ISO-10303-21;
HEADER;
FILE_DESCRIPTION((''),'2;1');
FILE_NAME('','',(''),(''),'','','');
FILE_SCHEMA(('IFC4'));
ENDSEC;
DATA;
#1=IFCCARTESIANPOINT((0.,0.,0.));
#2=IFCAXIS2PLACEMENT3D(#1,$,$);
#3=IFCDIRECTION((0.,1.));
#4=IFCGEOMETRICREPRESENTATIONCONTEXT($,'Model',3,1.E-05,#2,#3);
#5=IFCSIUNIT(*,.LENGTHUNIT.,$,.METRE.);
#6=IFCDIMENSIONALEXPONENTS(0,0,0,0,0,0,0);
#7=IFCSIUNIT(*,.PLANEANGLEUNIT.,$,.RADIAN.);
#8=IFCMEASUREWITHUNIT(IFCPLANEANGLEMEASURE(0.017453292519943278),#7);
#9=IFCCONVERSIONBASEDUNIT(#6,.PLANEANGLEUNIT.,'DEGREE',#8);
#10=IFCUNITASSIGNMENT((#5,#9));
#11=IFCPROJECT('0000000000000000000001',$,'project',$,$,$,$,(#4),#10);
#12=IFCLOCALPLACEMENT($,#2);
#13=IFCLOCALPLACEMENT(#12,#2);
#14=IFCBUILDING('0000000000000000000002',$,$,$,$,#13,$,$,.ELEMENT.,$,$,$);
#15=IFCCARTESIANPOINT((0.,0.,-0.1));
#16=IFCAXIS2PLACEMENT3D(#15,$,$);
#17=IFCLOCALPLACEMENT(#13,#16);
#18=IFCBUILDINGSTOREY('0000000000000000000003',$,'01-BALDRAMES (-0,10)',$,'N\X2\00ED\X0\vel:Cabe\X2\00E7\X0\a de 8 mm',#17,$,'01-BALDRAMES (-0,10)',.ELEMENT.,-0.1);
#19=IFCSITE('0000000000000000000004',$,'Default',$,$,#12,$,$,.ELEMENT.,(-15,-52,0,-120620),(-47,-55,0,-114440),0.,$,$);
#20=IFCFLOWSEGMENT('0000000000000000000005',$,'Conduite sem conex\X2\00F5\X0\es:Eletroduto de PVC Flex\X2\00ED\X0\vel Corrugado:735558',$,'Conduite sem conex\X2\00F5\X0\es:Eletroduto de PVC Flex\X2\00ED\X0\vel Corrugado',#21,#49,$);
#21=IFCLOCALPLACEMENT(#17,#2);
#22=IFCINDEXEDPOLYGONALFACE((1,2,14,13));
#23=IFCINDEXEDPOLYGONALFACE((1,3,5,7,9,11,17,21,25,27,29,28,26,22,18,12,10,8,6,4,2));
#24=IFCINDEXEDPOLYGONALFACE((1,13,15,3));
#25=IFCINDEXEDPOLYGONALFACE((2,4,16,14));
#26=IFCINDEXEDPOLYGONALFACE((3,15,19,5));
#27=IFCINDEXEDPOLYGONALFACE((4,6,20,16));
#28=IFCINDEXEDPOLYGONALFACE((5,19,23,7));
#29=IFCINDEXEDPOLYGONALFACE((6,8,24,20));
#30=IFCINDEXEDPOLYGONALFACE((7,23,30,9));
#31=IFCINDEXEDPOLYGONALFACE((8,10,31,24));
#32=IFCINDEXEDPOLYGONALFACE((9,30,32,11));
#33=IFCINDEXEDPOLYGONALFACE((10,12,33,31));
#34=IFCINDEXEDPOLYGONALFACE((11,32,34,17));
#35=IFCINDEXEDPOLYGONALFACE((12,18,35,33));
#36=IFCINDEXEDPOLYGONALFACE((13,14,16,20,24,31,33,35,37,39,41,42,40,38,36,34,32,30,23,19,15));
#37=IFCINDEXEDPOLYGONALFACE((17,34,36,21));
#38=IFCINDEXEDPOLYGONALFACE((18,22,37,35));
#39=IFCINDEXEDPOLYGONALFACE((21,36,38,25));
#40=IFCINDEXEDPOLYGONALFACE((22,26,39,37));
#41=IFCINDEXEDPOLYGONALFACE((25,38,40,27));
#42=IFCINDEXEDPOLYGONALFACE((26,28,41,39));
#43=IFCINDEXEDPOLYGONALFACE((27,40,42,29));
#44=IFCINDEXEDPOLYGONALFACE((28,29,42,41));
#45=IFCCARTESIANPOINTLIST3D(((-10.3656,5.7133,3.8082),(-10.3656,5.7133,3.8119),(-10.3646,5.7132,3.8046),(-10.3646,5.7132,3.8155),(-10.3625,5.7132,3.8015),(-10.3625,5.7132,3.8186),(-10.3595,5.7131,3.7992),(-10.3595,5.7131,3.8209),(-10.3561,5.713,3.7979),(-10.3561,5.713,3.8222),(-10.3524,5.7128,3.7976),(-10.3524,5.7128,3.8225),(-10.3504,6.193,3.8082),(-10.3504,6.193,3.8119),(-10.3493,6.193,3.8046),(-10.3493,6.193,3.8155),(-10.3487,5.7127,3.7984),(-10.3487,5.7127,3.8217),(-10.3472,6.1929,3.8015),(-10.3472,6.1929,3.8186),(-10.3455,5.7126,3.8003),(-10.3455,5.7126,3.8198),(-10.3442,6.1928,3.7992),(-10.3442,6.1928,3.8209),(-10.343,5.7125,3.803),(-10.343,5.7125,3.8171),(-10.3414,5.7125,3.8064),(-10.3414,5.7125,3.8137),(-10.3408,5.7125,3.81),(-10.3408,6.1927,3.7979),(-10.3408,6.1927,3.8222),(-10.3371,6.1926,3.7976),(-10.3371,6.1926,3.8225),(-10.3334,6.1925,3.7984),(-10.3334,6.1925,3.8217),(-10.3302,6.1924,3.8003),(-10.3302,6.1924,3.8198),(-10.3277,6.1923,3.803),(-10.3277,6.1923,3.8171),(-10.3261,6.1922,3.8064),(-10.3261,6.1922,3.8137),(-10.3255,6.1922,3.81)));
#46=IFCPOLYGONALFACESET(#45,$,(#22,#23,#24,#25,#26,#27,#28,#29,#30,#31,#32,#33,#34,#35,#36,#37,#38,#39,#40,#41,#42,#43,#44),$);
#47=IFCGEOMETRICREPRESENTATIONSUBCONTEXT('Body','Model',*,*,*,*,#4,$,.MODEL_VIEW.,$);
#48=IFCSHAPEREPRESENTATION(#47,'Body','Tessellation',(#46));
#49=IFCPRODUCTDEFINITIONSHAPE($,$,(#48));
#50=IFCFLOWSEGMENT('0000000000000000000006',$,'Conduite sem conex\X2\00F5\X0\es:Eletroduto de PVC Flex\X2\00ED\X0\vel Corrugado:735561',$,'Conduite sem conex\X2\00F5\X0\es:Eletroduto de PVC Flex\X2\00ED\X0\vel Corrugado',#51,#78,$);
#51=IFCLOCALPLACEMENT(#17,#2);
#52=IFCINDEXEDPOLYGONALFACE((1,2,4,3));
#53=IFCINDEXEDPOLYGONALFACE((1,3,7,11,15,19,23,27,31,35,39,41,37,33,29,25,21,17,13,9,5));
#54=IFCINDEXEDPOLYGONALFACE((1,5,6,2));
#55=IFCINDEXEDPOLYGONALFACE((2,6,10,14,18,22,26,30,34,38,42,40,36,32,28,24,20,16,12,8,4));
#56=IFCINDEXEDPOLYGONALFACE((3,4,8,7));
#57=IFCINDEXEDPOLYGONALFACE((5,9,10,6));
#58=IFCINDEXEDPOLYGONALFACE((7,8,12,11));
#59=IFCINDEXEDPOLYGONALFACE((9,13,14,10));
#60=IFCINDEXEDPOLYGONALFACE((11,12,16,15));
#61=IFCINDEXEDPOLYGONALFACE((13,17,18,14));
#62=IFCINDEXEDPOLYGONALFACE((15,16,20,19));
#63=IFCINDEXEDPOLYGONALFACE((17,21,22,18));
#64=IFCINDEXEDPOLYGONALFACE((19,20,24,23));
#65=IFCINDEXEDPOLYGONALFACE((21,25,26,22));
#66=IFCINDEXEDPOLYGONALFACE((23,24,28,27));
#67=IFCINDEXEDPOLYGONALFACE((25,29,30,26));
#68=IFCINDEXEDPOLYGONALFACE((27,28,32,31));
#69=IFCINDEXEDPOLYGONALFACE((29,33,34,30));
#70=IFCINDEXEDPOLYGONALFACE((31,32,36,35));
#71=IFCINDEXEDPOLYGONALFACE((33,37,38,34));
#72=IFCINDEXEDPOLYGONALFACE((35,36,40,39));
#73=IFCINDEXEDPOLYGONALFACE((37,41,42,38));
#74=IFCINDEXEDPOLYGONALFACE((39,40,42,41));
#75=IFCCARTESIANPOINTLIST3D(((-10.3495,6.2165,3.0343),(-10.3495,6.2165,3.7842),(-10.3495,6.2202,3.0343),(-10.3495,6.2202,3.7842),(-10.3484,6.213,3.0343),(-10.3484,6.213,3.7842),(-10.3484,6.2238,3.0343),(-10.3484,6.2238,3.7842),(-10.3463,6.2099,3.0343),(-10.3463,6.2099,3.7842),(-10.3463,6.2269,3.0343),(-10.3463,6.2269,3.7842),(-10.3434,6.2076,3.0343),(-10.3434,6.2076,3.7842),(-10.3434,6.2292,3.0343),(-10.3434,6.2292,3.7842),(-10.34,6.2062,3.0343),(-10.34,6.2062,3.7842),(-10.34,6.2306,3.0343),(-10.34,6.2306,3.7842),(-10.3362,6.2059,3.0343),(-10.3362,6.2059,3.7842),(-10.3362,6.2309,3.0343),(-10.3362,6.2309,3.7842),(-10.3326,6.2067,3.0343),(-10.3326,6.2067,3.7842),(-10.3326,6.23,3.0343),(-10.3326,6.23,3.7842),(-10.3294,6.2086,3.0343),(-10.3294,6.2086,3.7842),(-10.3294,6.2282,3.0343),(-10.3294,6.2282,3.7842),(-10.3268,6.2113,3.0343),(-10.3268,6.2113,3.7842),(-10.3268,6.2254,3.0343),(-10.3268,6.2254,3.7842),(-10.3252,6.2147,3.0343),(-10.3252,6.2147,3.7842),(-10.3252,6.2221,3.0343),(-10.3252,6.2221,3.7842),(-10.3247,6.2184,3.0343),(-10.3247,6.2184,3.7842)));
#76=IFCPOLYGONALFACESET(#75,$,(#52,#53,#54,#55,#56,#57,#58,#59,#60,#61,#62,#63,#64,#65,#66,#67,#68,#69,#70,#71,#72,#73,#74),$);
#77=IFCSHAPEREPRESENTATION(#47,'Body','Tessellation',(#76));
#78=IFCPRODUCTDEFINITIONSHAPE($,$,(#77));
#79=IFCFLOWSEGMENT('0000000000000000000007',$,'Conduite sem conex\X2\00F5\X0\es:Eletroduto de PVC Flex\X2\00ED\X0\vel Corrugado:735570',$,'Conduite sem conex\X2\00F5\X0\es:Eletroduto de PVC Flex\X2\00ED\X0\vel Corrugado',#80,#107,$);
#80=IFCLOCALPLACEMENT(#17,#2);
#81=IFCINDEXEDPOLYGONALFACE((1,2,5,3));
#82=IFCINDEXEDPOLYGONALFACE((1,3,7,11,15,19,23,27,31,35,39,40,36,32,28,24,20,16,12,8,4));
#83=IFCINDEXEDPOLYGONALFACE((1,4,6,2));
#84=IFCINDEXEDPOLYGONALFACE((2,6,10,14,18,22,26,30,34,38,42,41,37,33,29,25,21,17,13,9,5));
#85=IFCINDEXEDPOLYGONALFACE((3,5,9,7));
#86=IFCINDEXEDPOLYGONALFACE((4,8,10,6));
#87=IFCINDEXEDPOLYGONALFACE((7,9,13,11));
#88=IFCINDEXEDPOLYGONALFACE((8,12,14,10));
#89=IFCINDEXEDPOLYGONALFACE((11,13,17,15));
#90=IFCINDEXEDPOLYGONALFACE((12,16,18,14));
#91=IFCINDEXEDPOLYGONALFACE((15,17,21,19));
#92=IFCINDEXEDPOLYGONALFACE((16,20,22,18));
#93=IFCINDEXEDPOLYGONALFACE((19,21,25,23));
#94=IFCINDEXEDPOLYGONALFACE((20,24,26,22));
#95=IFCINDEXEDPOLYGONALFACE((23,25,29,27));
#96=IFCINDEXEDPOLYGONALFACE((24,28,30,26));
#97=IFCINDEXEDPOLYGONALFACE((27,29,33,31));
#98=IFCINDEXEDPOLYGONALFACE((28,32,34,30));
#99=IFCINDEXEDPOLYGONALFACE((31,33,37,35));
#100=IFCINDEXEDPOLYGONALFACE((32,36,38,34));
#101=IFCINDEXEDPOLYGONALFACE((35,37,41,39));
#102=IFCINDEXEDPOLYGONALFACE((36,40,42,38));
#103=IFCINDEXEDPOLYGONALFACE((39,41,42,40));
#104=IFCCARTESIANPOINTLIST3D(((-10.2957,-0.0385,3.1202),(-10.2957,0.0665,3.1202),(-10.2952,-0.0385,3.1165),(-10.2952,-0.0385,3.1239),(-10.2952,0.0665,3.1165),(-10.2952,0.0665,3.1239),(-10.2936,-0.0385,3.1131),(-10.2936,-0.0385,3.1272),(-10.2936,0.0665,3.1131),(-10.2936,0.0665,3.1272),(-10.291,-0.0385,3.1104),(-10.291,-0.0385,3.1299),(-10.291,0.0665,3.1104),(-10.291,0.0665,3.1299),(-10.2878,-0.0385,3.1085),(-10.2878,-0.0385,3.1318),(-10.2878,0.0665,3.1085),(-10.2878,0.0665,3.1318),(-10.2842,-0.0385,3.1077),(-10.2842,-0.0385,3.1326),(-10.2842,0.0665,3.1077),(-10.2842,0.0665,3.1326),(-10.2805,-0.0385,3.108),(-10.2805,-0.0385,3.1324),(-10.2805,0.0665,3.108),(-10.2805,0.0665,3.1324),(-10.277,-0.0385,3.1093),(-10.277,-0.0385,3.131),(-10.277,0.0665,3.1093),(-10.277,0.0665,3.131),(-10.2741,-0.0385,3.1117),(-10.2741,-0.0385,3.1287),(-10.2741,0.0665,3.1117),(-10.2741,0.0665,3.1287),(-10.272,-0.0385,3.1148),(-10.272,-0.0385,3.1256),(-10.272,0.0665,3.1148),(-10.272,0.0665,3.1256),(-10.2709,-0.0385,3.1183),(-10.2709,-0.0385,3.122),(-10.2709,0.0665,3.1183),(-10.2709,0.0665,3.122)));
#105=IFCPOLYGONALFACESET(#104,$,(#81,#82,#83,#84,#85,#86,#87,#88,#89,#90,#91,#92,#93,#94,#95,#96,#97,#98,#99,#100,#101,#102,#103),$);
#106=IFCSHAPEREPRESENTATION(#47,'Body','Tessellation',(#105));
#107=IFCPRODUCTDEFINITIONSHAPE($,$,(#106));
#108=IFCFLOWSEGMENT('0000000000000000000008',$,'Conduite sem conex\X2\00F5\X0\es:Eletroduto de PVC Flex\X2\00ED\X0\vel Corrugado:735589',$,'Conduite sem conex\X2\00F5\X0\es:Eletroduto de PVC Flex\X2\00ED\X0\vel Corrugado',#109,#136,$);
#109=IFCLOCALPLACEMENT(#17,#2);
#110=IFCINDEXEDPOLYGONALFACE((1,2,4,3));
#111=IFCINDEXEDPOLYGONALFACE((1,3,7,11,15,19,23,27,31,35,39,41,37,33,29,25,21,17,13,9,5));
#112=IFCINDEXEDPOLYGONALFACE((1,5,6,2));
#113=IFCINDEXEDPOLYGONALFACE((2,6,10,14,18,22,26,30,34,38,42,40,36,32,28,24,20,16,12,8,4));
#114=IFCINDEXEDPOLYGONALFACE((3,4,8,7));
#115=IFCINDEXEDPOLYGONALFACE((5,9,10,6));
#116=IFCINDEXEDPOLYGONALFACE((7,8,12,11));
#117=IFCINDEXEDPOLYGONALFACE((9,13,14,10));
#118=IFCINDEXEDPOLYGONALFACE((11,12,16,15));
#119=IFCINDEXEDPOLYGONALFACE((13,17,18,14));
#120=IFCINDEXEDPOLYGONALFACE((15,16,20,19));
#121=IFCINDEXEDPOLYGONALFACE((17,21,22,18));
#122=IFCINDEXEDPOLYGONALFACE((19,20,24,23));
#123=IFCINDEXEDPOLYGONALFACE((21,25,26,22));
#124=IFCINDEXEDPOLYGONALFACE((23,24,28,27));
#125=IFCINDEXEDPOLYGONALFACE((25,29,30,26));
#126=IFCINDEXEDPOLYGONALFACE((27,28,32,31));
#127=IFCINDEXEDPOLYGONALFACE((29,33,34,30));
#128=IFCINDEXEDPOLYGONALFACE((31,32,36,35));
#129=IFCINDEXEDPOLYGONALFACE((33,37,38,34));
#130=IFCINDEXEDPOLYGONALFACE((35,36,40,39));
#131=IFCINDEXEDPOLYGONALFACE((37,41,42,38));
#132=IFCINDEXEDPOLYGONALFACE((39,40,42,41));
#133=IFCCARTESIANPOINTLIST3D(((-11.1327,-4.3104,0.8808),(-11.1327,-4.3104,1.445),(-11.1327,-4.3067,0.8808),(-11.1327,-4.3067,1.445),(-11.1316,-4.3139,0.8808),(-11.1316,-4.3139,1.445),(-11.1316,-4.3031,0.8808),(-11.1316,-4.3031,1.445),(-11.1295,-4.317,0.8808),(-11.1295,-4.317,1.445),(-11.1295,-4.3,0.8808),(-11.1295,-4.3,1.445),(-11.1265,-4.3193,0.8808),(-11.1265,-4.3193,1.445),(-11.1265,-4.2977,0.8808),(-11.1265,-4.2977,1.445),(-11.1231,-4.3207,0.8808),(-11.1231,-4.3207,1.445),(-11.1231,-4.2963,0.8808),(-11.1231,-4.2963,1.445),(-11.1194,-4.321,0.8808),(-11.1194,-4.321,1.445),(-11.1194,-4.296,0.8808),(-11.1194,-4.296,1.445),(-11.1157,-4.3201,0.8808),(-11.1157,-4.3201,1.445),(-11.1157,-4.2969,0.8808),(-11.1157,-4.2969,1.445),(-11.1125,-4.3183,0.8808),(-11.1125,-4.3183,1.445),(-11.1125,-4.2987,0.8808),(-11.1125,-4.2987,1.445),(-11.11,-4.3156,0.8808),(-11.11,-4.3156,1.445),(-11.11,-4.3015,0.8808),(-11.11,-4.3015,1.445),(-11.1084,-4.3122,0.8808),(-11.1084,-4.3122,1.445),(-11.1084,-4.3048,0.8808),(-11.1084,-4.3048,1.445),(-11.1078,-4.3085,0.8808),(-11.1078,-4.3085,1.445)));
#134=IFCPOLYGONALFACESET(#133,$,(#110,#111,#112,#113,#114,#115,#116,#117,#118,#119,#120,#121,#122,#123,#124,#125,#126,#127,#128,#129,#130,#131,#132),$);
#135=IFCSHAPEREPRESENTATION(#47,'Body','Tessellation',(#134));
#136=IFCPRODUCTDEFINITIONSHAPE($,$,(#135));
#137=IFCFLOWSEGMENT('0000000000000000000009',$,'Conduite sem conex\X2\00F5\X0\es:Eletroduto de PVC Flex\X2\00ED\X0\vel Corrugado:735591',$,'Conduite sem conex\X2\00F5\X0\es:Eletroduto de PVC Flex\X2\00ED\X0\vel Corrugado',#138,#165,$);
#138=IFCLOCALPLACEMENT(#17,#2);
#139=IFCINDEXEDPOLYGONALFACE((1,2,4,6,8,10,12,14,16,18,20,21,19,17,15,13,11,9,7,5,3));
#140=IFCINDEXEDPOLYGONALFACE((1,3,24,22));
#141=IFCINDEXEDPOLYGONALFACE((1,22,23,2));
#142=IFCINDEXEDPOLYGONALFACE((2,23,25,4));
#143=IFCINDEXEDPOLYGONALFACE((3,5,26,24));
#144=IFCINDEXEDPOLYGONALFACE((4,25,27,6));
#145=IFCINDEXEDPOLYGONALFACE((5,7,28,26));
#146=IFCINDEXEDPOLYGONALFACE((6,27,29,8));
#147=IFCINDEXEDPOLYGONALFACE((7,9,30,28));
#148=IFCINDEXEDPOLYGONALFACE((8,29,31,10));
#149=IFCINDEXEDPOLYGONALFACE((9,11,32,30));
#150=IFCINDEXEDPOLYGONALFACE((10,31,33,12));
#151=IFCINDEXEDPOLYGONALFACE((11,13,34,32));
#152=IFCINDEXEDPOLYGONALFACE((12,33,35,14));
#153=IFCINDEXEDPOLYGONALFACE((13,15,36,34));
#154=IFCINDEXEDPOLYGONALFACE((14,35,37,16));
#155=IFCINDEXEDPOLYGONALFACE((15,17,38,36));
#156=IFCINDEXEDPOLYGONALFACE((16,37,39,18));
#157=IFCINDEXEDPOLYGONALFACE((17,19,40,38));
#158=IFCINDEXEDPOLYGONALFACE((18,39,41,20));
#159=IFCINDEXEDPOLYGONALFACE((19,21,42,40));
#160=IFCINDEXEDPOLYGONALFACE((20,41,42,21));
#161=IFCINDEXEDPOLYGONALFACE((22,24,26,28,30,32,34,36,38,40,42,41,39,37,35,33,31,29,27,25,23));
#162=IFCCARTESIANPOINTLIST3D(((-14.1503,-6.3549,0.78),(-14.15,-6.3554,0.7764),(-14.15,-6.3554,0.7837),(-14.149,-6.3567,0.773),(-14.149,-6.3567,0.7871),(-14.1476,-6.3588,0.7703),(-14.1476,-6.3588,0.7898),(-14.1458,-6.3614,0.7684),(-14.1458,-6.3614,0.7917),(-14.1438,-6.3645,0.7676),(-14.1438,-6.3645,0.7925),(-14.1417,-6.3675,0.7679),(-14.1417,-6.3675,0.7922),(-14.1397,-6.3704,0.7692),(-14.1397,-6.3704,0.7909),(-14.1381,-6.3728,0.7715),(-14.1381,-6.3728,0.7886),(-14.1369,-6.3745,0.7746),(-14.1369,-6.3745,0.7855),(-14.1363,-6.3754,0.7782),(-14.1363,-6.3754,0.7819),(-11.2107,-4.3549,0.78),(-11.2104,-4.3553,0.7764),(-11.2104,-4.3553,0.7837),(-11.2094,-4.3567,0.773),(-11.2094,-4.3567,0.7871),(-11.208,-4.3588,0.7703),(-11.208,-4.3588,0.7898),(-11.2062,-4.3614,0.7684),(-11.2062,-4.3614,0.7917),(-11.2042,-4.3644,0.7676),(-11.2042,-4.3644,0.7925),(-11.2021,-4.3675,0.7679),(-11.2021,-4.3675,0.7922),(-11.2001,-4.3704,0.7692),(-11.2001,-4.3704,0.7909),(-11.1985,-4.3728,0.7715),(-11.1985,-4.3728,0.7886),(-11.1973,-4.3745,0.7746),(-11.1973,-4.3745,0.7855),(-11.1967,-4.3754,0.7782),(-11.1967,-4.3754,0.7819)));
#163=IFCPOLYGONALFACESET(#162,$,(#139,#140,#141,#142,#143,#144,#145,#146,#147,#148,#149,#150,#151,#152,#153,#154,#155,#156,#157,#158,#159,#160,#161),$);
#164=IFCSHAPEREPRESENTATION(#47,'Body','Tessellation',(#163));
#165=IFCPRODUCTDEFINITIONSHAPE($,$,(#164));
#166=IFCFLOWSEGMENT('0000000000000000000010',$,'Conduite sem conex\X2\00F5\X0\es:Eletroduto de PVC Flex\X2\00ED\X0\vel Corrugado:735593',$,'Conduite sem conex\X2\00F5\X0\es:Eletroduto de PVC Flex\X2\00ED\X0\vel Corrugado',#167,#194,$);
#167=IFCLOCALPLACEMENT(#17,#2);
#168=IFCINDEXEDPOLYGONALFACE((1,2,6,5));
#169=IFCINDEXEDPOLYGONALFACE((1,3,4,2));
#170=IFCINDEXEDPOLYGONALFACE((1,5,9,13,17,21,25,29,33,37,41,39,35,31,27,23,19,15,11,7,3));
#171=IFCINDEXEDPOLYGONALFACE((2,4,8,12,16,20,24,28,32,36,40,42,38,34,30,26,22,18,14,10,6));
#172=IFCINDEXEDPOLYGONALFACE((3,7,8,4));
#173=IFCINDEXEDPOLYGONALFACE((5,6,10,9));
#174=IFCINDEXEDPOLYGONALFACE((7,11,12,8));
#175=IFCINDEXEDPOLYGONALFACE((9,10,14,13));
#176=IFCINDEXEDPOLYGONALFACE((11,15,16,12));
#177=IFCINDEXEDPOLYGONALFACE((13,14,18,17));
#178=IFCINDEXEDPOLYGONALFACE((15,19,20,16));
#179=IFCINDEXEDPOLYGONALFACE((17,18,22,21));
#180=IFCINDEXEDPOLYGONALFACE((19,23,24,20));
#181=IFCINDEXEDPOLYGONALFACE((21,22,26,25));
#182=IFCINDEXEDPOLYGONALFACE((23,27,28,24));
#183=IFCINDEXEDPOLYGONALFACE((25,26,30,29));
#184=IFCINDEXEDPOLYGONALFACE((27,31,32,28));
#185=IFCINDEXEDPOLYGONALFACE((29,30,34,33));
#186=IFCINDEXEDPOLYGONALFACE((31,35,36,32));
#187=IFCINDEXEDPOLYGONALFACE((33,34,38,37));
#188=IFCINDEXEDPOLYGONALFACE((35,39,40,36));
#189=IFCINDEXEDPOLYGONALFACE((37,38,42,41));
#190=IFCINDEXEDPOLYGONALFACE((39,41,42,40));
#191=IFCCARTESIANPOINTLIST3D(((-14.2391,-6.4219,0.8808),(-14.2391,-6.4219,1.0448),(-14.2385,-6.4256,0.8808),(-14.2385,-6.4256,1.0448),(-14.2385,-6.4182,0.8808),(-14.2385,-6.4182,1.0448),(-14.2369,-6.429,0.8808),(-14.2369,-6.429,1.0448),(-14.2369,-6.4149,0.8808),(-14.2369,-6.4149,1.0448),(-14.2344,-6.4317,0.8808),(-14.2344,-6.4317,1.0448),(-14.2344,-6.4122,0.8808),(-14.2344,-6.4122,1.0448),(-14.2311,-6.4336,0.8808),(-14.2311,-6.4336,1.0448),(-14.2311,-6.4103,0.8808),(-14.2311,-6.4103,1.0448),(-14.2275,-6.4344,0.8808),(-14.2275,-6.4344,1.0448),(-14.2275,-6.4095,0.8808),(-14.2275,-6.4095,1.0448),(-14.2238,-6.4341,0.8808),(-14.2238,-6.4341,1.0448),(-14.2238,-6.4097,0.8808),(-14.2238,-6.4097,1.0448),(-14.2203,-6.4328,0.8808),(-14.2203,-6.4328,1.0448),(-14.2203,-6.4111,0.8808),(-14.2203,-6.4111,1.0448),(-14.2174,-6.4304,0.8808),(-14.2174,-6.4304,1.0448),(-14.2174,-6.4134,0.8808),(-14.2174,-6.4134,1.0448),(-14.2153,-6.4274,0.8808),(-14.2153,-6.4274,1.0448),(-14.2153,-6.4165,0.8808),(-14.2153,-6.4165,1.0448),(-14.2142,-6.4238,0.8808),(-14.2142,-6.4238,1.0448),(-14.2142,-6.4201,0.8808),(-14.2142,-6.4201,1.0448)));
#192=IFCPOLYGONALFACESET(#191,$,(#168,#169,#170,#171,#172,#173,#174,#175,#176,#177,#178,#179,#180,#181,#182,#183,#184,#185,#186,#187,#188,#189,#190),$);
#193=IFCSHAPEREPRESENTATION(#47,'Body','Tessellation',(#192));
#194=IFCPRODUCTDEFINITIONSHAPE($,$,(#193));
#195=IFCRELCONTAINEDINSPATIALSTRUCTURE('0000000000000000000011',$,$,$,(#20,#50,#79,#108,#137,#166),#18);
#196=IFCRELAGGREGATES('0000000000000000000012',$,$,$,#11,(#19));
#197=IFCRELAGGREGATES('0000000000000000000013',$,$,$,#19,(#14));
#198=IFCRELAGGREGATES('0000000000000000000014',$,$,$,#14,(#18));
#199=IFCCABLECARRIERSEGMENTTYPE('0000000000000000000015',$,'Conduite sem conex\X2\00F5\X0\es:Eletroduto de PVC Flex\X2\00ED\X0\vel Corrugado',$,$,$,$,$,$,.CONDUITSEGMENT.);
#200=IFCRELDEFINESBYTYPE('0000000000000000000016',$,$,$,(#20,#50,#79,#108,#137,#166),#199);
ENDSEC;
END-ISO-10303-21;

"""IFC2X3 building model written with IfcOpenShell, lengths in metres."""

from ifc_helpers import new_model, entity, si_unit, converted_unit, direction, frame, frame_2d, origin, origin_2d_with_axis, place, context, subcontext, project, spatial, circle, extrude, type_object, element, save


model = new_model("IFC2X3")

# Units and contexts
model_context = context("Model", 3, precision=1e-05, world=origin(), true_north=direction((0.0, 1.0)))
body_context = subcontext(model_context, "Body", "Model", "MODEL_VIEW")
ifc_project = project(units=[si_unit("LENGTHUNIT", "METRE"), converted_unit("PLANEANGLEUNIT", "DEGREE", entity("IfcPlaneAngleMeasure", 0.017453292519943278), si_unit("PLANEANGLEUNIT", "RADIAN"), dimensions=[0, 0, 0, 0, 0, 0, 0])], contexts=[model_context])

# Site, building, storey
site_placement = place(None, origin())
site = spatial("IfcSite", under=ifc_project, at=site_placement, Name="Default", CompositionType="ELEMENT", RefLatitude=(-15, -52, 0, -120620), RefLongitude=(-47, -55, 0, -114440), RefElevation=0.0)
building_placement = place(site_placement, origin())
building = spatial("IfcBuilding", under=site, at=building_placement, CompositionType="ELEMENT")
storey_placement = place(building_placement, frame((0.0, 0.0, -0.1)))
storey = spatial("IfcBuildingStorey", under=building, at=storey_placement, Name="01-BALDRAMES (-0,10)", ObjectType="Nível:Cabeça de 8 mm", LongName="01-BALDRAMES (-0,10)", CompositionType="ELEMENT", Elevation=-0.1)

# Flow segments
cable_carrier_segment_type = type_object("IfcCableCarrierSegmentType", Name="Conduite sem conexões:Eletroduto de PVC Flexível Corrugado", PredefinedType="CONDUITSEGMENT")
flow_segment_1_placement = place(storey_placement, origin())
element("IfcFlowSegment", 1, at=flow_segment_1_placement, inside=storey, type_object=cable_carrier_segment_type, Name="Conduite sem conexões:Eletroduto de PVC Flexível Corrugado:735558", ObjectType="Conduite sem conexões:Eletroduto de PVC Flexível Corrugado", context=body_context, shape_type="SweptSolid", body=[
    extrude(circle(Radius=0.0125, at=origin_2d_with_axis()), frame((-10.3533, 5.7129, 3.81), z_axis=(0.031867, 0.999492, 0.0), x_axis=(0.999492, -0.031867, 0.0)), (0.0, 0.0, 1.0), 0.48),
])
flow_segment_2_placement = place(storey_placement, origin())
element("IfcFlowSegment", 2, at=flow_segment_2_placement, inside=storey, type_object=cable_carrier_segment_type, Name="Conduite sem conexões:Eletroduto de PVC Flexível Corrugado:735561", ObjectType="Conduite sem conexões:Eletroduto de PVC Flexível Corrugado", context=body_context, shape_type="SweptSolid", body=[
    extrude(circle(Radius=0.0125, at=frame_2d((0.0, 0.0), x_axis=(1.0, 0.0))), frame((-10.3372, 6.2184, 3.0343)), (0.0, 0.0, 1.0), 0.75),
])
flow_segment_3_placement = place(storey_placement, origin())
element("IfcFlowSegment", 3, at=flow_segment_3_placement, inside=storey, type_object=cable_carrier_segment_type, Name="Conduite sem conexões:Eletroduto de PVC Flexível Corrugado:735570", ObjectType="Conduite sem conexões:Eletroduto de PVC Flexível Corrugado", context=body_context, shape_type="SweptSolid", body=[
    extrude(circle(Radius=0.0125, at=frame_2d((0.0, 0.0), x_axis=(1.0, 0.0))), frame((-10.2832, 0.0665, 3.1202), z_axis=(0.000017, -1.0, 0.0), x_axis=(-1.0, -0.000017, 0.0)), (0.0, 0.0, 1.0), 0.105),
])
flow_segment_4_placement = place(storey_placement, origin())
element("IfcFlowSegment", 4, at=flow_segment_4_placement, inside=storey, type_object=cable_carrier_segment_type, Name="Conduite sem conexões:Eletroduto de PVC Flexível Corrugado:735589", ObjectType="Conduite sem conexões:Eletroduto de PVC Flexível Corrugado", context=body_context, shape_type="SweptSolid", body=[
    extrude(circle(Radius=0.0125, at=frame_2d((0.0, 0.0), x_axis=(1.0, 0.0))), frame((-11.1203, -4.3085, 0.8808)), (0.0, 0.0, 1.0), 0.5642),
])
flow_segment_5_placement = place(storey_placement, origin())
element("IfcFlowSegment", 5, at=flow_segment_5_placement, inside=storey, type_object=cable_carrier_segment_type, Name="Conduite sem conexões:Eletroduto de PVC Flexível Corrugado:735591", ObjectType="Conduite sem conexões:Eletroduto de PVC Flexível Corrugado", context=body_context, shape_type="SweptSolid", body=[
    extrude(circle(Radius=0.0125, at=frame_2d((0.0, 0.0), x_axis=(1.0, 0.0))), frame((-14.1432, -6.3652, 0.78), z_axis=(0.826785, 0.562518, 0.0), x_axis=(-0.562518, 0.826785, 0.0)), (0.0, 0.0, 1.0), 3.5555),
])
flow_segment_6_placement = place(storey_placement, origin())
element("IfcFlowSegment", 6, at=flow_segment_6_placement, inside=storey, type_object=cable_carrier_segment_type, Name="Conduite sem conexões:Eletroduto de PVC Flexível Corrugado:735593", ObjectType="Conduite sem conexões:Eletroduto de PVC Flexível Corrugado", context=body_context, shape_type="SweptSolid", body=[
    extrude(circle(Radius=0.0125, at=origin_2d_with_axis()), frame((-14.2266, -6.4219, 0.8808), z_axis=(0.0, 0.0, 1.0), x_axis=(-1.0, 0.0, 0.0)), (0.0, 0.0, 1.0), 0.164),
])

save(model, "model.ifc")
